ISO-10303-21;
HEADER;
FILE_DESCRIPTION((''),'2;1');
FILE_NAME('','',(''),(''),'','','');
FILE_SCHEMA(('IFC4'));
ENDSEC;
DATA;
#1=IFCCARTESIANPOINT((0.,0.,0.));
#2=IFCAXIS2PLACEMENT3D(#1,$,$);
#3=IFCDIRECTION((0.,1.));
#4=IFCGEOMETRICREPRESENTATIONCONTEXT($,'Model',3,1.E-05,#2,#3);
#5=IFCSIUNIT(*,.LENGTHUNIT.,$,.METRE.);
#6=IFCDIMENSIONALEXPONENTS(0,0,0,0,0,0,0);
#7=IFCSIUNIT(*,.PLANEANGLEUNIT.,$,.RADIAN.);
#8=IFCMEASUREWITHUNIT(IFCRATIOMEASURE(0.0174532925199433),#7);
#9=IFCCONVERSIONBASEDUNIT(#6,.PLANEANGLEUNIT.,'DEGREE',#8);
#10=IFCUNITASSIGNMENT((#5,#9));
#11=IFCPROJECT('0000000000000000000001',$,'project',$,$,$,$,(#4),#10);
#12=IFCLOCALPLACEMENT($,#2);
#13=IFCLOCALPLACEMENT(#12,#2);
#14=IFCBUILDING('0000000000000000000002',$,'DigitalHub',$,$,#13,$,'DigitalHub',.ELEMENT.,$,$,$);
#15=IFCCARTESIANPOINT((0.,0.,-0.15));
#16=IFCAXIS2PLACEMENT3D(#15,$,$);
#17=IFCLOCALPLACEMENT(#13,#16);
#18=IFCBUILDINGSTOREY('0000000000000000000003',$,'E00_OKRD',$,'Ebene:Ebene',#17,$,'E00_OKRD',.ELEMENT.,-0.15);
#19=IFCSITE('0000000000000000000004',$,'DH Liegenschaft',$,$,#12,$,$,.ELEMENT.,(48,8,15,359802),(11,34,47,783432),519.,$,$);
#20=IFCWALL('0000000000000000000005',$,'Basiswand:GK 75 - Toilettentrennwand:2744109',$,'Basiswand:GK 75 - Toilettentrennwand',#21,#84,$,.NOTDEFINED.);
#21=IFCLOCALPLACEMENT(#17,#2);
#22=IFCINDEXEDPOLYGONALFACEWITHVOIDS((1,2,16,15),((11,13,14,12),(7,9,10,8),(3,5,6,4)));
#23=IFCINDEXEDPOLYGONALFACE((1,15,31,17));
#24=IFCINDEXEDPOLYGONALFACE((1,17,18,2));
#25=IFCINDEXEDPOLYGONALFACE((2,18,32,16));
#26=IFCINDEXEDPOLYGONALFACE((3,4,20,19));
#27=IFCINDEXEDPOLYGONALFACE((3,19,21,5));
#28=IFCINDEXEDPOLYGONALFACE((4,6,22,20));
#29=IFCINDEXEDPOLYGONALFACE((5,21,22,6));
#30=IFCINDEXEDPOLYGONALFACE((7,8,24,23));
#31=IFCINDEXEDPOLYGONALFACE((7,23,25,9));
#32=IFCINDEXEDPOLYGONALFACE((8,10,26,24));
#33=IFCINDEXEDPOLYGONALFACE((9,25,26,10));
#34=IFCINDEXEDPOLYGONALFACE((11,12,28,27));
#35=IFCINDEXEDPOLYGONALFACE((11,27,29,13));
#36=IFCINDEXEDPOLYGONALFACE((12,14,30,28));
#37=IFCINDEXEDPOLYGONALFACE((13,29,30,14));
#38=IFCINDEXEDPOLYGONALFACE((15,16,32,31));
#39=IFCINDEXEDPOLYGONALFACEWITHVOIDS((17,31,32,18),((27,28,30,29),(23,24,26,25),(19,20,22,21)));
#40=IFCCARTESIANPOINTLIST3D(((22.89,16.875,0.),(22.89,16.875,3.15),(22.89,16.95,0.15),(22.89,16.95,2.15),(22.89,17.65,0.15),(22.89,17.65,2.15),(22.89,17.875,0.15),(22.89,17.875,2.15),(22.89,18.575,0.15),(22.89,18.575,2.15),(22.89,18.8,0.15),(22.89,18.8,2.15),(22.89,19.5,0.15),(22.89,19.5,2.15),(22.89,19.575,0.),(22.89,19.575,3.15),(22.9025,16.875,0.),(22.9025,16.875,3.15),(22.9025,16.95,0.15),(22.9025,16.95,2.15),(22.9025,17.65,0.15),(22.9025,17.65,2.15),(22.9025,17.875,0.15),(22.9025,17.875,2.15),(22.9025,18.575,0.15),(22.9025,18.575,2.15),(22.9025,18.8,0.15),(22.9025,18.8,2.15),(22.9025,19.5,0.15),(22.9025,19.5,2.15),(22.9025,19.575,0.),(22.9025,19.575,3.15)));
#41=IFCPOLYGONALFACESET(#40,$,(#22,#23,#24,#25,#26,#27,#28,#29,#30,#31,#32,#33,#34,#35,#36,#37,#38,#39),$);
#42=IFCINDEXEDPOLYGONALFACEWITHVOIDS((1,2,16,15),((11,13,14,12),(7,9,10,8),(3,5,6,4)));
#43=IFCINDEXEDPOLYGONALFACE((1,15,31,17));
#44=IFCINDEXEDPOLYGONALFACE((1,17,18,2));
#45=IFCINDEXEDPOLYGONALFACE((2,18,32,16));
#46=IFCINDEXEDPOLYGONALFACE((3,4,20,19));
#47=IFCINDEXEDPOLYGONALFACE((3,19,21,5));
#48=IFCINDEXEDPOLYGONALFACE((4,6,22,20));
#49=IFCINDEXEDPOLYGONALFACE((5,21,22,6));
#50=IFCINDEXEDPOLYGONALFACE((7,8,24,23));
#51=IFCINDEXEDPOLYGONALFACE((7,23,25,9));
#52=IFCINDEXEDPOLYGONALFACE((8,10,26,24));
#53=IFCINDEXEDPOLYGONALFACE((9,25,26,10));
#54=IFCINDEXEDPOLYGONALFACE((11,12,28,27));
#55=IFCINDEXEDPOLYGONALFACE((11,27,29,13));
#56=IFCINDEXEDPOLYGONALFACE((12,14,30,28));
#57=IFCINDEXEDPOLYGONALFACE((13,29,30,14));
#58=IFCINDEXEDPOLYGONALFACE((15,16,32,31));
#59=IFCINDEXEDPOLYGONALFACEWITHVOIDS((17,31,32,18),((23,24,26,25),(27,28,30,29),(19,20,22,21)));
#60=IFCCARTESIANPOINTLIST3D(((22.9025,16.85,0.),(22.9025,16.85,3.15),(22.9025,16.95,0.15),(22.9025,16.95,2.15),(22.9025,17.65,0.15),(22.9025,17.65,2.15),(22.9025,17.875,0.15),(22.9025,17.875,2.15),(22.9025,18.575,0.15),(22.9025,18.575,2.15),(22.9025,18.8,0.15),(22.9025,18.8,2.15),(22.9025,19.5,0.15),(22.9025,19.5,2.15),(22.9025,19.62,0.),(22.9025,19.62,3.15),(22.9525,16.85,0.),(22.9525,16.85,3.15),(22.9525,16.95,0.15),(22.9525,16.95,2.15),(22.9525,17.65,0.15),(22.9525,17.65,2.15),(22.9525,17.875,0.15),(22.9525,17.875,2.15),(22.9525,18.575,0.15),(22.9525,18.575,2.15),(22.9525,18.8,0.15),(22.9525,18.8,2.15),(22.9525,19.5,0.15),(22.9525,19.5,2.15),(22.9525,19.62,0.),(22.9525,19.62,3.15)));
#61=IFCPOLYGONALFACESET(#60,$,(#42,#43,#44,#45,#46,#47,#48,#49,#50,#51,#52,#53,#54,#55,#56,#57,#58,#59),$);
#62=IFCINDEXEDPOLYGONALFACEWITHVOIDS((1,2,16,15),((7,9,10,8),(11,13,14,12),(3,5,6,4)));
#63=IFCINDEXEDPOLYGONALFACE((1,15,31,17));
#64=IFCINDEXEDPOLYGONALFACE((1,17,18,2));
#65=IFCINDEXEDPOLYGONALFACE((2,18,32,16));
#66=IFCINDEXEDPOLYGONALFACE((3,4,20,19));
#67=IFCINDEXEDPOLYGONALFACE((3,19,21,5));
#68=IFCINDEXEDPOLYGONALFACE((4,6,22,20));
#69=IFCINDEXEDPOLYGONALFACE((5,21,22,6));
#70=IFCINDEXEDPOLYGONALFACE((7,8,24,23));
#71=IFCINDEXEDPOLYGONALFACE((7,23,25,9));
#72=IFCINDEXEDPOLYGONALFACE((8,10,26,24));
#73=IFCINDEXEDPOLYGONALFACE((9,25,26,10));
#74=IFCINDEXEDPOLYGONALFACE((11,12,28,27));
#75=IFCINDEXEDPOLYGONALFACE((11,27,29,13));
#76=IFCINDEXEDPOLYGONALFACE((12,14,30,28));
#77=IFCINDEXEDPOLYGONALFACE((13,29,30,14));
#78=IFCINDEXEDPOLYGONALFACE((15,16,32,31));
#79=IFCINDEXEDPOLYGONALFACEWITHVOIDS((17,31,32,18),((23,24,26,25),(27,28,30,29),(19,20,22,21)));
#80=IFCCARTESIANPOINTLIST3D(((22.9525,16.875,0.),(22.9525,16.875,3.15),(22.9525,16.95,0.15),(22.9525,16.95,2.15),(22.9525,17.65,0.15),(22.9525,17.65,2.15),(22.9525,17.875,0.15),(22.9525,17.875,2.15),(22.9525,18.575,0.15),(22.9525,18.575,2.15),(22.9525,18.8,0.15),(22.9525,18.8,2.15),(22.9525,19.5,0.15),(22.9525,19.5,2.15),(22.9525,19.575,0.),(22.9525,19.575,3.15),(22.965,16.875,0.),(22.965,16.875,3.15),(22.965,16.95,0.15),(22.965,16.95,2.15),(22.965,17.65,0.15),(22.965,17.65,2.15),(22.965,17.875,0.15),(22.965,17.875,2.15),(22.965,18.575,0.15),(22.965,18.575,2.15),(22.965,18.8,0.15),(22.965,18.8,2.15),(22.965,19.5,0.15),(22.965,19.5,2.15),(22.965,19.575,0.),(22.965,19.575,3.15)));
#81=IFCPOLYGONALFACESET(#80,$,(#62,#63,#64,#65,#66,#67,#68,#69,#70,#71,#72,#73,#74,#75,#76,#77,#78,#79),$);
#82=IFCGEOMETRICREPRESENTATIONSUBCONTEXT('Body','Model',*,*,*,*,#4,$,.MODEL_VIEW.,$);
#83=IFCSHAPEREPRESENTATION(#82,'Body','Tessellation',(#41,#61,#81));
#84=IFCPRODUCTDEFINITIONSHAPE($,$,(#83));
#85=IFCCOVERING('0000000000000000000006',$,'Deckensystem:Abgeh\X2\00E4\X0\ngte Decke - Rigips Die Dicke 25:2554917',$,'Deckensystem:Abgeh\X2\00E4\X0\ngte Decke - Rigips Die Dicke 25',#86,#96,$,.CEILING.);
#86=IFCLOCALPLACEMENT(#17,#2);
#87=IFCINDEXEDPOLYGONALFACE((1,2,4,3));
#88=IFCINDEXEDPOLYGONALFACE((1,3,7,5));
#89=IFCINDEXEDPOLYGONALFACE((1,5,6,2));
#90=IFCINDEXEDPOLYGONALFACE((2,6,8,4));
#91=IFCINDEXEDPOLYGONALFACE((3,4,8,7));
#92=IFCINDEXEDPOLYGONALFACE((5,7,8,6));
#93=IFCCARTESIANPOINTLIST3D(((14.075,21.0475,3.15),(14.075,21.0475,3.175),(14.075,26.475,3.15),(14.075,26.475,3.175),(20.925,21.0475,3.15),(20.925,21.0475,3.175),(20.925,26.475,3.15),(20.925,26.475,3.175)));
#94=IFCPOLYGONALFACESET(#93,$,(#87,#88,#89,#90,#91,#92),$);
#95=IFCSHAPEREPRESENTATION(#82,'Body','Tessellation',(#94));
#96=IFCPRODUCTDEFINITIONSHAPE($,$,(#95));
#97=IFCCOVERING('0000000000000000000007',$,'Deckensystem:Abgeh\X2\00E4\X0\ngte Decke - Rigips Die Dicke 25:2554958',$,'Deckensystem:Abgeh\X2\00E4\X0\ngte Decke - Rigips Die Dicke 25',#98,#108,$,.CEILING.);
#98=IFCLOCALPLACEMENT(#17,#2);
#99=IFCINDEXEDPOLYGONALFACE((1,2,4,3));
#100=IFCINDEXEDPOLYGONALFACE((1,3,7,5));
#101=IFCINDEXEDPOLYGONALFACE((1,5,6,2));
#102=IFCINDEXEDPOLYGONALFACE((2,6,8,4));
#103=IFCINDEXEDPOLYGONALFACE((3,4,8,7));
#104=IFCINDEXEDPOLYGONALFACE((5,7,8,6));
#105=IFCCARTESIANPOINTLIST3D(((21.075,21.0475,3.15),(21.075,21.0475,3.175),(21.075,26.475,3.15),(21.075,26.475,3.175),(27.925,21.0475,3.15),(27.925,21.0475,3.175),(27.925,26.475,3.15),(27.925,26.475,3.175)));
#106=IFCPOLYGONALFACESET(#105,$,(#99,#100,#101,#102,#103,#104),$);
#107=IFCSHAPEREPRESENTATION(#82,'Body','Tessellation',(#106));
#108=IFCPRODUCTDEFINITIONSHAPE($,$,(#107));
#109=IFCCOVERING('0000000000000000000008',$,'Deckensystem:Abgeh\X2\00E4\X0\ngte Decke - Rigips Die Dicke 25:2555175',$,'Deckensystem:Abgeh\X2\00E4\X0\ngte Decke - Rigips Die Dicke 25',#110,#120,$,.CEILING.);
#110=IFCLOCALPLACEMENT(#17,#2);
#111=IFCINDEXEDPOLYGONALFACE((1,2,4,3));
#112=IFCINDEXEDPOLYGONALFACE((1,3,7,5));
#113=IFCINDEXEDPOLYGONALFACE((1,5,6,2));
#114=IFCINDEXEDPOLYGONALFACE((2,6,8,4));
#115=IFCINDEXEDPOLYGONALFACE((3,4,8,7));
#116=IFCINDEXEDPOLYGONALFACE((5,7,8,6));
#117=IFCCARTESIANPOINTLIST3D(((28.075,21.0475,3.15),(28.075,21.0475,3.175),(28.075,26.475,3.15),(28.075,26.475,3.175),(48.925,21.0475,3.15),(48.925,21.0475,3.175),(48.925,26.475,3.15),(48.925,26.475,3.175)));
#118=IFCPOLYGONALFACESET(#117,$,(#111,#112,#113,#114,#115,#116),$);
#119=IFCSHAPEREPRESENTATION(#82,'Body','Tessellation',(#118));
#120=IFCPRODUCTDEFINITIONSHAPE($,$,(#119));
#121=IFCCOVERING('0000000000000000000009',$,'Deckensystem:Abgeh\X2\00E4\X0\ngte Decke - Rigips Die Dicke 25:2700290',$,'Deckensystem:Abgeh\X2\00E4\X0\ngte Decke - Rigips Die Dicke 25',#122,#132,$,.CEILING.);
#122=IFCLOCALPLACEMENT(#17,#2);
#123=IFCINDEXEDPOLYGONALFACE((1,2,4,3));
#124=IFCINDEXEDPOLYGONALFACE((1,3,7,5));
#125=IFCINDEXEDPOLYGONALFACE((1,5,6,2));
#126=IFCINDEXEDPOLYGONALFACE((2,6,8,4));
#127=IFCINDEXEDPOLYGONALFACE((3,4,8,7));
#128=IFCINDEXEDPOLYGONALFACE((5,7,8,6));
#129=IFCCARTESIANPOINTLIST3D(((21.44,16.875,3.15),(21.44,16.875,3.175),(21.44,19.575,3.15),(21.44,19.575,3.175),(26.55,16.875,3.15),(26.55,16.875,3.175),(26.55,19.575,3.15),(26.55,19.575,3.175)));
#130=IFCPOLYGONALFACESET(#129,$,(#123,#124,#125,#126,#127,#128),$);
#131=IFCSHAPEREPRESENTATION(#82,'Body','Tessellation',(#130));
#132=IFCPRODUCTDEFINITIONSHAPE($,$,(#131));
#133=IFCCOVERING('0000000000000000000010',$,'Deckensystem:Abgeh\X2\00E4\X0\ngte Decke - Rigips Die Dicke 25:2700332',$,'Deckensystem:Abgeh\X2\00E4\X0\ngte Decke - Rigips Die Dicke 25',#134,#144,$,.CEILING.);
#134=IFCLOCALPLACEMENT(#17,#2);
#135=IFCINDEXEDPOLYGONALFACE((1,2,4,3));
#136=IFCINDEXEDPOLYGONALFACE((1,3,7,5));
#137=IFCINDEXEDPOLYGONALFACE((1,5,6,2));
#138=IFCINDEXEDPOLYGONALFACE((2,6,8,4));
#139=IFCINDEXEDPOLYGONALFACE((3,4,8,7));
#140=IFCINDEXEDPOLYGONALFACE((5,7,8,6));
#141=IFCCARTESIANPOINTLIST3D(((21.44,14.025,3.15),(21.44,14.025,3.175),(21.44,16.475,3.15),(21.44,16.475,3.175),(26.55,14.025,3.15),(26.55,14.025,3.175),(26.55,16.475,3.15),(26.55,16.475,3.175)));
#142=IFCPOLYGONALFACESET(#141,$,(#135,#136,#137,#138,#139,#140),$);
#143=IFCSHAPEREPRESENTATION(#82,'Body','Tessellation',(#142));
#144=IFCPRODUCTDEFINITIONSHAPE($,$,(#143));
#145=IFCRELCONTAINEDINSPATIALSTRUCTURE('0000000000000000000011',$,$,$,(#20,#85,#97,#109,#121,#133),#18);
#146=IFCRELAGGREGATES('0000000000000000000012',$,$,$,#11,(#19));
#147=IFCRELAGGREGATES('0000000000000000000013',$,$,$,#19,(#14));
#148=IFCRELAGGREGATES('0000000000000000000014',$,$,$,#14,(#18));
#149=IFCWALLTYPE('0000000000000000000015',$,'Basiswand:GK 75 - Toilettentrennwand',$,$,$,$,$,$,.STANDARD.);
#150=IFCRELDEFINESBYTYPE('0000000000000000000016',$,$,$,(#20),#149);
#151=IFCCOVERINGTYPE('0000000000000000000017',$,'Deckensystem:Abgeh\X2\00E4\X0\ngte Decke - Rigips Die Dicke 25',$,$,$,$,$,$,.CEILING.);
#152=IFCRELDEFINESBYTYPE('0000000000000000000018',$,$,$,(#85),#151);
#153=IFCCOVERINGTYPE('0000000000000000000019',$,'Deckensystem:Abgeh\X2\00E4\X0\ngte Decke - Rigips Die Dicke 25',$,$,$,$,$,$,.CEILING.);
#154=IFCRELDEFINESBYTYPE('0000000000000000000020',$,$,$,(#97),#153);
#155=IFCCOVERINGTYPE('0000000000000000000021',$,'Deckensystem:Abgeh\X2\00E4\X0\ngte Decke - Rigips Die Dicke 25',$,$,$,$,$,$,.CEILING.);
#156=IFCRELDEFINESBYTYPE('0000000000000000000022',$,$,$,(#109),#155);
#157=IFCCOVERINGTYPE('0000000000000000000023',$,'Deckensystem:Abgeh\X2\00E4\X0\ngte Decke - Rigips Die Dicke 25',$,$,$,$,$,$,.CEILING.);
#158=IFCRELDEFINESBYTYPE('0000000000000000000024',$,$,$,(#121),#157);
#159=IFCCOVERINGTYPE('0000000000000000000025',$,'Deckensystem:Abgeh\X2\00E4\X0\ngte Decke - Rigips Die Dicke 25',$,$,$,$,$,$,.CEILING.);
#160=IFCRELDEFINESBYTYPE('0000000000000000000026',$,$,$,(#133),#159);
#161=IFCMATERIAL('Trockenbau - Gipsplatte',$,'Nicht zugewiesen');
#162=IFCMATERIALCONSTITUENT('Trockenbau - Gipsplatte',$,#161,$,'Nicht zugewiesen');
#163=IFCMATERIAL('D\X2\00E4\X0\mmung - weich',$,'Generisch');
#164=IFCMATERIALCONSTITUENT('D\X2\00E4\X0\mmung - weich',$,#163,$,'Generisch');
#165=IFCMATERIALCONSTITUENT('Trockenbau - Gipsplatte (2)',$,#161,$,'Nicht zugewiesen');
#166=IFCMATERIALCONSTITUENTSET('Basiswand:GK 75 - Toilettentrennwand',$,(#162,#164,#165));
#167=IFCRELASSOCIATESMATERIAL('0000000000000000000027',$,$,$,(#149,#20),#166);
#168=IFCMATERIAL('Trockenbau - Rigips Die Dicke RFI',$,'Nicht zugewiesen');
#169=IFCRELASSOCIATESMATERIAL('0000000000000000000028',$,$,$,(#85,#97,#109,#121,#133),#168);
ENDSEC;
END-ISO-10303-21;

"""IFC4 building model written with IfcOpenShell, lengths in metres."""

from ifc_helpers import new_model, entity, si_unit, converted_unit, direction, frame, origin, place, context, subcontext, project, spatial, indexed_curve, outline, extrude, material, constituent, constituent_set, type_object, element, save


model = new_model("IFC4")

# Units and contexts
model_context = context("Model", 3, precision=1e-05, world=origin(), true_north=direction((0.0, 1.0)))
body_context = subcontext(model_context, "Body", "Model", "MODEL_VIEW")
ifc_project = project(units=[si_unit("LENGTHUNIT", "METRE"), converted_unit("PLANEANGLEUNIT", "DEGREE", entity("IfcRatioMeasure", 0.0174532925199433), si_unit("PLANEANGLEUNIT", "RADIAN"), dimensions=[0, 0, 0, 0, 0, 0, 0])], contexts=[model_context])

# Site, building, storey
site_placement = place(None, frame((0.0, 0.0, 0.0)))
site = spatial("IfcSite", under=ifc_project, at=site_placement, Name="DH Liegenschaft", CompositionType="ELEMENT", RefLatitude=(48, 8, 15, 359802), RefLongitude=(11, 34, 47, 783432), RefElevation=519.0)
building_placement = place(site_placement, origin())
building = spatial("IfcBuilding", under=site, at=building_placement, Name="DigitalHub", LongName="DigitalHub", CompositionType="ELEMENT")
storey_placement = place(building_placement, frame((0.0, 0.0, -0.15)))
storey = spatial("IfcBuildingStorey", under=building, at=storey_placement, Name="E00_OKRD", ObjectType="Ebene:Ebene", LongName="E00_OKRD", CompositionType="ELEMENT", Elevation=-0.15)

# Shared definitions
ifc_material_1 = material(Name="Trockenbau - Gipsplatte", Category="Nicht zugewiesen")
ifc_material_2 = material(Name="Dämmung - weich", Category="Generisch")
ifc_constituent_1 = constituent(ifc_material_1, Name="Trockenbau - Gipsplatte", Category="Nicht zugewiesen")
ifc_constituent_2 = constituent(ifc_material_2, Name="Dämmung - weich", Category="Generisch")
ifc_constituent_3 = constituent(ifc_material_1, Name="Trockenbau - Gipsplatte (2)", Category="Nicht zugewiesen")
ifc_constituent_set_1 = constituent_set(constituents=[ifc_constituent_1, ifc_constituent_2, ifc_constituent_3], Name="Basiswand:GK 75 - Toilettentrennwand")
wall_type_1 = type_object("IfcWallType", Name="Basiswand:GK 75 - Toilettentrennwand", PredefinedType="STANDARD", material=ifc_constituent_set_1)

# Wall, openings
wall_1_placement = place(storey_placement, frame((22.9275, 19.575, 0.0), z_axis=(0.0, 0.0, 1.0), x_axis=(0.0, -1.0, 0.0)))
wall_1 = element("IfcWall", 1, at=wall_1_placement, inside=storey, type_object=wall_type_1, material=ifc_constituent_set_1, Name="Basiswand:GK 75 - Toilettentrennwand:2744109", ObjectType="Basiswand:GK 75 - Toilettentrennwand", PredefinedType="NOTDEFINED", context=body_context, shape_type="SweptSolid", body=[
    extrude(outline(indexed_curve([(-1.575, -1.35), (1.575, -1.35), (1.575, -0.5), (1.575, -0.425), (1.575, 0.425), (1.575, 0.5), (1.575, 1.35), (-1.575, 1.35), (-1.575, 0.5), (-1.575, 0.425), (-1.575, -0.425), (-1.575, -0.5), (-1.575, -1.35)], self_intersect=False), holes=[indexed_curve([(0.575, 0.575), (-1.425, 0.575), (-1.425, 1.275), (0.575, 1.275), (0.575, 0.575)], self_intersect=False), indexed_curve([(0.575, -0.35), (-1.425, -0.35), (-1.425, 0.35), (0.575, 0.35), (0.575, -0.35)], self_intersect=False), indexed_curve([(0.575, -1.275), (-1.425, -1.275), (-1.425, -0.575), (0.575, -0.575), (0.575, -1.275)], self_intersect=False)]), frame((1.35, -0.0375, 1.575), z_axis=(0.0, 1.0, 0.0), x_axis=(0.0, 0.0, 1.0)), (0.0, 0.0, 1.0), 0.0125),
    extrude(outline(indexed_curve([(-1.575, -1.385), (1.575, -1.385), (1.575, 1.385), (-1.575, 1.385), (-1.575, -1.385)], self_intersect=False), holes=[indexed_curve([(0.575, -1.265), (-1.425, -1.265), (-1.425, -0.565), (0.575, -0.565), (0.575, -1.265)], self_intersect=False), indexed_curve([(0.575, -0.34), (-1.425, -0.34), (-1.425, 0.36), (0.575, 0.36), (0.575, -0.34)], self_intersect=False), indexed_curve([(0.575, 0.585), (-1.425, 0.585), (-1.425, 1.285), (0.575, 1.285), (0.575, 0.585)], self_intersect=False)]), frame((1.34, -0.025, 1.575), z_axis=(0.0, 1.0, 0.0), x_axis=(0.0, 0.0, 1.0)), (0.0, 0.0, 1.0), 0.05),
    extrude(outline(indexed_curve([(-1.575, -1.35), (1.575, -1.35), (1.575, 1.35), (-1.575, 1.35), (-1.575, -1.35)], self_intersect=False), holes=[indexed_curve([(0.575, -1.275), (-1.425, -1.275), (-1.425, -0.575), (0.575, -0.575), (0.575, -1.275)], self_intersect=False), indexed_curve([(0.575, -0.35), (-1.425, -0.35), (-1.425, 0.35), (0.575, 0.35), (0.575, -0.35)], self_intersect=False), indexed_curve([(0.575, 0.575), (-1.425, 0.575), (-1.425, 1.275), (0.575, 1.275), (0.575, 0.575)], self_intersect=False)]), frame((1.35, 0.025, 1.575), z_axis=(0.0, 1.0, 0.0), x_axis=(0.0, 0.0, 1.0)), (0.0, 0.0, 1.0), 0.0125),
])
opening_1_placement = place(wall_1_placement, frame((2.625, -0.0375, 0.15)))
element("IfcOpeningElement", 2, at=opening_1_placement, cuts=wall_1, PredefinedType="OPENING", context=body_context, shape_type="SweptSolid", body=[
    extrude(outline(indexed_curve([(-1.0, -0.35), (1.0, -0.35), (1.0, 0.35), (-1.0, 0.35), (-1.0, -0.35)], self_intersect=False)), frame((-0.35, 0.0, 1.0), z_axis=(0.0, 1.0, 0.0), x_axis=(0.0, 0.0, -1.0)), (0.0, 0.0, 1.0), 0.075),
])
opening_2_placement = place(wall_1_placement, frame((1.7, -0.0375, 0.15)))
element("IfcOpeningElement", 3, at=opening_2_placement, cuts=wall_1, PredefinedType="OPENING", context=body_context, shape_type="SweptSolid", body=[
    extrude(outline(indexed_curve([(-1.0, -0.35), (1.0, -0.35), (1.0, 0.35), (-1.0, 0.35), (-1.0, -0.35)], self_intersect=False)), frame((-0.35, 0.0, 1.0), z_axis=(0.0, 1.0, 0.0), x_axis=(0.0, 0.0, -1.0)), (0.0, 0.0, 1.0), 0.075),
])
opening_3_placement = place(wall_1_placement, frame((0.775, -0.0375, 0.15)))
element("IfcOpeningElement", 4, at=opening_3_placement, cuts=wall_1, PredefinedType="OPENING", context=body_context, shape_type="SweptSolid", body=[
    extrude(outline(indexed_curve([(-1.0, -0.35), (1.0, -0.35), (1.0, 0.35), (-1.0, 0.35), (-1.0, -0.35)], self_intersect=False)), frame((-0.35, 0.0, 1.0), z_axis=(0.0, 1.0, 0.0), x_axis=(0.0, 0.0, -1.0)), (0.0, 0.0, 1.0), 0.075),
])

# Coverings
ifc_material_3 = material(Name="Trockenbau - Rigips Die Dicke RFI", Category="Nicht zugewiesen")
covering_type_1 = type_object("IfcCoveringType", Name="Deckensystem:Abgehängte Decke - Rigips Die Dicke 25", PredefinedType="CEILING")
covering_1_placement = place(storey_placement, frame((14.075, 21.0475, 3.15)))
element("IfcCovering", 5, at=covering_1_placement, inside=storey, type_object=covering_type_1, material=ifc_material_3, Name="Deckensystem:Abgehängte Decke - Rigips Die Dicke 25:2554917", ObjectType="Deckensystem:Abgehängte Decke - Rigips Die Dicke 25", PredefinedType="CEILING", context=body_context, shape_type="SweptSolid", body=[
    extrude(outline(indexed_curve([(-3.425, -2.7137), (3.425, -2.7137), (3.425, 2.7137), (-3.425, 2.7137), (-3.425, -2.7137)], self_intersect=False)), frame((3.425, 2.7137, 0.0), z_axis=(0.0, 0.0, 1.0), x_axis=(-1.0, 0.0, 0.0)), (0.0, 0.0, 1.0), 0.025),
])
covering_type_2 = type_object("IfcCoveringType", Name="Deckensystem:Abgehängte Decke - Rigips Die Dicke 25", PredefinedType="CEILING")
covering_2_placement = place(storey_placement, frame((21.075, 21.0475, 3.15)))
element("IfcCovering", 6, at=covering_2_placement, inside=storey, type_object=covering_type_2, material=ifc_material_3, Name="Deckensystem:Abgehängte Decke - Rigips Die Dicke 25:2554958", ObjectType="Deckensystem:Abgehängte Decke - Rigips Die Dicke 25", PredefinedType="CEILING", context=body_context, shape_type="SweptSolid", body=[
    extrude(outline(indexed_curve([(-3.425, -2.7137), (3.425, -2.7137), (3.425, 2.7137), (-3.425, 2.7137), (-3.425, -2.7137)], self_intersect=False)), frame((3.425, 2.7137, 0.0), z_axis=(0.0, 0.0, 1.0), x_axis=(-1.0, 0.0, 0.0)), (0.0, 0.0, 1.0), 0.025),
])
covering_type_3 = type_object("IfcCoveringType", Name="Deckensystem:Abgehängte Decke - Rigips Die Dicke 25", PredefinedType="CEILING")
covering_3_placement = place(storey_placement, frame((28.075, 21.0475, 3.15)))
element("IfcCovering", 7, at=covering_3_placement, inside=storey, type_object=covering_type_3, material=ifc_material_3, Name="Deckensystem:Abgehängte Decke - Rigips Die Dicke 25:2555175", ObjectType="Deckensystem:Abgehängte Decke - Rigips Die Dicke 25", PredefinedType="CEILING", context=body_context, shape_type="SweptSolid", body=[
    extrude(outline(indexed_curve([(-10.425, -2.7137), (10.425, -2.7137), (10.425, 2.7137), (-10.425, 2.7137), (-10.425, -2.7137)], self_intersect=False)), frame((10.425, 2.7137, 0.0), z_axis=(0.0, 0.0, 1.0), x_axis=(-1.0, 0.0, 0.0)), (0.0, 0.0, 1.0), 0.025),
])
covering_type_4 = type_object("IfcCoveringType", Name="Deckensystem:Abgehängte Decke - Rigips Die Dicke 25", PredefinedType="CEILING")
covering_4_placement = place(storey_placement, frame((21.44, 16.875, 3.15)))
element("IfcCovering", 8, at=covering_4_placement, inside=storey, type_object=covering_type_4, material=ifc_material_3, Name="Deckensystem:Abgehängte Decke - Rigips Die Dicke 25:2700290", ObjectType="Deckensystem:Abgehängte Decke - Rigips Die Dicke 25", PredefinedType="CEILING", context=body_context, shape_type="SweptSolid", body=[
    extrude(outline(indexed_curve([(-2.555, -1.35), (2.555, -1.35), (2.555, 1.35), (-2.555, 1.35), (-2.555, -1.35)], self_intersect=False)), frame((2.555, 1.35, 0.0), z_axis=(0.0, 0.0, 1.0), x_axis=(-1.0, 0.0, 0.0)), (0.0, 0.0, 1.0), 0.025),
])
covering_type_5 = type_object("IfcCoveringType", Name="Deckensystem:Abgehängte Decke - Rigips Die Dicke 25", PredefinedType="CEILING")
covering_5_placement = place(storey_placement, frame((21.44, 14.025, 3.15)))
element("IfcCovering", 9, at=covering_5_placement, inside=storey, type_object=covering_type_5, material=ifc_material_3, Name="Deckensystem:Abgehängte Decke - Rigips Die Dicke 25:2700332", ObjectType="Deckensystem:Abgehängte Decke - Rigips Die Dicke 25", PredefinedType="CEILING", context=body_context, shape_type="SweptSolid", body=[
    extrude(outline(indexed_curve([(-2.555, -1.225), (2.555, -1.225), (2.555, 1.225), (-2.555, 1.225), (-2.555, -1.225)], self_intersect=False)), frame((2.555, 1.225, 0.0), z_axis=(0.0, 0.0, 1.0), x_axis=(-1.0, 0.0, 0.0)), (0.0, 0.0, 1.0), 0.025),
])

save(model, "model.ifc")
